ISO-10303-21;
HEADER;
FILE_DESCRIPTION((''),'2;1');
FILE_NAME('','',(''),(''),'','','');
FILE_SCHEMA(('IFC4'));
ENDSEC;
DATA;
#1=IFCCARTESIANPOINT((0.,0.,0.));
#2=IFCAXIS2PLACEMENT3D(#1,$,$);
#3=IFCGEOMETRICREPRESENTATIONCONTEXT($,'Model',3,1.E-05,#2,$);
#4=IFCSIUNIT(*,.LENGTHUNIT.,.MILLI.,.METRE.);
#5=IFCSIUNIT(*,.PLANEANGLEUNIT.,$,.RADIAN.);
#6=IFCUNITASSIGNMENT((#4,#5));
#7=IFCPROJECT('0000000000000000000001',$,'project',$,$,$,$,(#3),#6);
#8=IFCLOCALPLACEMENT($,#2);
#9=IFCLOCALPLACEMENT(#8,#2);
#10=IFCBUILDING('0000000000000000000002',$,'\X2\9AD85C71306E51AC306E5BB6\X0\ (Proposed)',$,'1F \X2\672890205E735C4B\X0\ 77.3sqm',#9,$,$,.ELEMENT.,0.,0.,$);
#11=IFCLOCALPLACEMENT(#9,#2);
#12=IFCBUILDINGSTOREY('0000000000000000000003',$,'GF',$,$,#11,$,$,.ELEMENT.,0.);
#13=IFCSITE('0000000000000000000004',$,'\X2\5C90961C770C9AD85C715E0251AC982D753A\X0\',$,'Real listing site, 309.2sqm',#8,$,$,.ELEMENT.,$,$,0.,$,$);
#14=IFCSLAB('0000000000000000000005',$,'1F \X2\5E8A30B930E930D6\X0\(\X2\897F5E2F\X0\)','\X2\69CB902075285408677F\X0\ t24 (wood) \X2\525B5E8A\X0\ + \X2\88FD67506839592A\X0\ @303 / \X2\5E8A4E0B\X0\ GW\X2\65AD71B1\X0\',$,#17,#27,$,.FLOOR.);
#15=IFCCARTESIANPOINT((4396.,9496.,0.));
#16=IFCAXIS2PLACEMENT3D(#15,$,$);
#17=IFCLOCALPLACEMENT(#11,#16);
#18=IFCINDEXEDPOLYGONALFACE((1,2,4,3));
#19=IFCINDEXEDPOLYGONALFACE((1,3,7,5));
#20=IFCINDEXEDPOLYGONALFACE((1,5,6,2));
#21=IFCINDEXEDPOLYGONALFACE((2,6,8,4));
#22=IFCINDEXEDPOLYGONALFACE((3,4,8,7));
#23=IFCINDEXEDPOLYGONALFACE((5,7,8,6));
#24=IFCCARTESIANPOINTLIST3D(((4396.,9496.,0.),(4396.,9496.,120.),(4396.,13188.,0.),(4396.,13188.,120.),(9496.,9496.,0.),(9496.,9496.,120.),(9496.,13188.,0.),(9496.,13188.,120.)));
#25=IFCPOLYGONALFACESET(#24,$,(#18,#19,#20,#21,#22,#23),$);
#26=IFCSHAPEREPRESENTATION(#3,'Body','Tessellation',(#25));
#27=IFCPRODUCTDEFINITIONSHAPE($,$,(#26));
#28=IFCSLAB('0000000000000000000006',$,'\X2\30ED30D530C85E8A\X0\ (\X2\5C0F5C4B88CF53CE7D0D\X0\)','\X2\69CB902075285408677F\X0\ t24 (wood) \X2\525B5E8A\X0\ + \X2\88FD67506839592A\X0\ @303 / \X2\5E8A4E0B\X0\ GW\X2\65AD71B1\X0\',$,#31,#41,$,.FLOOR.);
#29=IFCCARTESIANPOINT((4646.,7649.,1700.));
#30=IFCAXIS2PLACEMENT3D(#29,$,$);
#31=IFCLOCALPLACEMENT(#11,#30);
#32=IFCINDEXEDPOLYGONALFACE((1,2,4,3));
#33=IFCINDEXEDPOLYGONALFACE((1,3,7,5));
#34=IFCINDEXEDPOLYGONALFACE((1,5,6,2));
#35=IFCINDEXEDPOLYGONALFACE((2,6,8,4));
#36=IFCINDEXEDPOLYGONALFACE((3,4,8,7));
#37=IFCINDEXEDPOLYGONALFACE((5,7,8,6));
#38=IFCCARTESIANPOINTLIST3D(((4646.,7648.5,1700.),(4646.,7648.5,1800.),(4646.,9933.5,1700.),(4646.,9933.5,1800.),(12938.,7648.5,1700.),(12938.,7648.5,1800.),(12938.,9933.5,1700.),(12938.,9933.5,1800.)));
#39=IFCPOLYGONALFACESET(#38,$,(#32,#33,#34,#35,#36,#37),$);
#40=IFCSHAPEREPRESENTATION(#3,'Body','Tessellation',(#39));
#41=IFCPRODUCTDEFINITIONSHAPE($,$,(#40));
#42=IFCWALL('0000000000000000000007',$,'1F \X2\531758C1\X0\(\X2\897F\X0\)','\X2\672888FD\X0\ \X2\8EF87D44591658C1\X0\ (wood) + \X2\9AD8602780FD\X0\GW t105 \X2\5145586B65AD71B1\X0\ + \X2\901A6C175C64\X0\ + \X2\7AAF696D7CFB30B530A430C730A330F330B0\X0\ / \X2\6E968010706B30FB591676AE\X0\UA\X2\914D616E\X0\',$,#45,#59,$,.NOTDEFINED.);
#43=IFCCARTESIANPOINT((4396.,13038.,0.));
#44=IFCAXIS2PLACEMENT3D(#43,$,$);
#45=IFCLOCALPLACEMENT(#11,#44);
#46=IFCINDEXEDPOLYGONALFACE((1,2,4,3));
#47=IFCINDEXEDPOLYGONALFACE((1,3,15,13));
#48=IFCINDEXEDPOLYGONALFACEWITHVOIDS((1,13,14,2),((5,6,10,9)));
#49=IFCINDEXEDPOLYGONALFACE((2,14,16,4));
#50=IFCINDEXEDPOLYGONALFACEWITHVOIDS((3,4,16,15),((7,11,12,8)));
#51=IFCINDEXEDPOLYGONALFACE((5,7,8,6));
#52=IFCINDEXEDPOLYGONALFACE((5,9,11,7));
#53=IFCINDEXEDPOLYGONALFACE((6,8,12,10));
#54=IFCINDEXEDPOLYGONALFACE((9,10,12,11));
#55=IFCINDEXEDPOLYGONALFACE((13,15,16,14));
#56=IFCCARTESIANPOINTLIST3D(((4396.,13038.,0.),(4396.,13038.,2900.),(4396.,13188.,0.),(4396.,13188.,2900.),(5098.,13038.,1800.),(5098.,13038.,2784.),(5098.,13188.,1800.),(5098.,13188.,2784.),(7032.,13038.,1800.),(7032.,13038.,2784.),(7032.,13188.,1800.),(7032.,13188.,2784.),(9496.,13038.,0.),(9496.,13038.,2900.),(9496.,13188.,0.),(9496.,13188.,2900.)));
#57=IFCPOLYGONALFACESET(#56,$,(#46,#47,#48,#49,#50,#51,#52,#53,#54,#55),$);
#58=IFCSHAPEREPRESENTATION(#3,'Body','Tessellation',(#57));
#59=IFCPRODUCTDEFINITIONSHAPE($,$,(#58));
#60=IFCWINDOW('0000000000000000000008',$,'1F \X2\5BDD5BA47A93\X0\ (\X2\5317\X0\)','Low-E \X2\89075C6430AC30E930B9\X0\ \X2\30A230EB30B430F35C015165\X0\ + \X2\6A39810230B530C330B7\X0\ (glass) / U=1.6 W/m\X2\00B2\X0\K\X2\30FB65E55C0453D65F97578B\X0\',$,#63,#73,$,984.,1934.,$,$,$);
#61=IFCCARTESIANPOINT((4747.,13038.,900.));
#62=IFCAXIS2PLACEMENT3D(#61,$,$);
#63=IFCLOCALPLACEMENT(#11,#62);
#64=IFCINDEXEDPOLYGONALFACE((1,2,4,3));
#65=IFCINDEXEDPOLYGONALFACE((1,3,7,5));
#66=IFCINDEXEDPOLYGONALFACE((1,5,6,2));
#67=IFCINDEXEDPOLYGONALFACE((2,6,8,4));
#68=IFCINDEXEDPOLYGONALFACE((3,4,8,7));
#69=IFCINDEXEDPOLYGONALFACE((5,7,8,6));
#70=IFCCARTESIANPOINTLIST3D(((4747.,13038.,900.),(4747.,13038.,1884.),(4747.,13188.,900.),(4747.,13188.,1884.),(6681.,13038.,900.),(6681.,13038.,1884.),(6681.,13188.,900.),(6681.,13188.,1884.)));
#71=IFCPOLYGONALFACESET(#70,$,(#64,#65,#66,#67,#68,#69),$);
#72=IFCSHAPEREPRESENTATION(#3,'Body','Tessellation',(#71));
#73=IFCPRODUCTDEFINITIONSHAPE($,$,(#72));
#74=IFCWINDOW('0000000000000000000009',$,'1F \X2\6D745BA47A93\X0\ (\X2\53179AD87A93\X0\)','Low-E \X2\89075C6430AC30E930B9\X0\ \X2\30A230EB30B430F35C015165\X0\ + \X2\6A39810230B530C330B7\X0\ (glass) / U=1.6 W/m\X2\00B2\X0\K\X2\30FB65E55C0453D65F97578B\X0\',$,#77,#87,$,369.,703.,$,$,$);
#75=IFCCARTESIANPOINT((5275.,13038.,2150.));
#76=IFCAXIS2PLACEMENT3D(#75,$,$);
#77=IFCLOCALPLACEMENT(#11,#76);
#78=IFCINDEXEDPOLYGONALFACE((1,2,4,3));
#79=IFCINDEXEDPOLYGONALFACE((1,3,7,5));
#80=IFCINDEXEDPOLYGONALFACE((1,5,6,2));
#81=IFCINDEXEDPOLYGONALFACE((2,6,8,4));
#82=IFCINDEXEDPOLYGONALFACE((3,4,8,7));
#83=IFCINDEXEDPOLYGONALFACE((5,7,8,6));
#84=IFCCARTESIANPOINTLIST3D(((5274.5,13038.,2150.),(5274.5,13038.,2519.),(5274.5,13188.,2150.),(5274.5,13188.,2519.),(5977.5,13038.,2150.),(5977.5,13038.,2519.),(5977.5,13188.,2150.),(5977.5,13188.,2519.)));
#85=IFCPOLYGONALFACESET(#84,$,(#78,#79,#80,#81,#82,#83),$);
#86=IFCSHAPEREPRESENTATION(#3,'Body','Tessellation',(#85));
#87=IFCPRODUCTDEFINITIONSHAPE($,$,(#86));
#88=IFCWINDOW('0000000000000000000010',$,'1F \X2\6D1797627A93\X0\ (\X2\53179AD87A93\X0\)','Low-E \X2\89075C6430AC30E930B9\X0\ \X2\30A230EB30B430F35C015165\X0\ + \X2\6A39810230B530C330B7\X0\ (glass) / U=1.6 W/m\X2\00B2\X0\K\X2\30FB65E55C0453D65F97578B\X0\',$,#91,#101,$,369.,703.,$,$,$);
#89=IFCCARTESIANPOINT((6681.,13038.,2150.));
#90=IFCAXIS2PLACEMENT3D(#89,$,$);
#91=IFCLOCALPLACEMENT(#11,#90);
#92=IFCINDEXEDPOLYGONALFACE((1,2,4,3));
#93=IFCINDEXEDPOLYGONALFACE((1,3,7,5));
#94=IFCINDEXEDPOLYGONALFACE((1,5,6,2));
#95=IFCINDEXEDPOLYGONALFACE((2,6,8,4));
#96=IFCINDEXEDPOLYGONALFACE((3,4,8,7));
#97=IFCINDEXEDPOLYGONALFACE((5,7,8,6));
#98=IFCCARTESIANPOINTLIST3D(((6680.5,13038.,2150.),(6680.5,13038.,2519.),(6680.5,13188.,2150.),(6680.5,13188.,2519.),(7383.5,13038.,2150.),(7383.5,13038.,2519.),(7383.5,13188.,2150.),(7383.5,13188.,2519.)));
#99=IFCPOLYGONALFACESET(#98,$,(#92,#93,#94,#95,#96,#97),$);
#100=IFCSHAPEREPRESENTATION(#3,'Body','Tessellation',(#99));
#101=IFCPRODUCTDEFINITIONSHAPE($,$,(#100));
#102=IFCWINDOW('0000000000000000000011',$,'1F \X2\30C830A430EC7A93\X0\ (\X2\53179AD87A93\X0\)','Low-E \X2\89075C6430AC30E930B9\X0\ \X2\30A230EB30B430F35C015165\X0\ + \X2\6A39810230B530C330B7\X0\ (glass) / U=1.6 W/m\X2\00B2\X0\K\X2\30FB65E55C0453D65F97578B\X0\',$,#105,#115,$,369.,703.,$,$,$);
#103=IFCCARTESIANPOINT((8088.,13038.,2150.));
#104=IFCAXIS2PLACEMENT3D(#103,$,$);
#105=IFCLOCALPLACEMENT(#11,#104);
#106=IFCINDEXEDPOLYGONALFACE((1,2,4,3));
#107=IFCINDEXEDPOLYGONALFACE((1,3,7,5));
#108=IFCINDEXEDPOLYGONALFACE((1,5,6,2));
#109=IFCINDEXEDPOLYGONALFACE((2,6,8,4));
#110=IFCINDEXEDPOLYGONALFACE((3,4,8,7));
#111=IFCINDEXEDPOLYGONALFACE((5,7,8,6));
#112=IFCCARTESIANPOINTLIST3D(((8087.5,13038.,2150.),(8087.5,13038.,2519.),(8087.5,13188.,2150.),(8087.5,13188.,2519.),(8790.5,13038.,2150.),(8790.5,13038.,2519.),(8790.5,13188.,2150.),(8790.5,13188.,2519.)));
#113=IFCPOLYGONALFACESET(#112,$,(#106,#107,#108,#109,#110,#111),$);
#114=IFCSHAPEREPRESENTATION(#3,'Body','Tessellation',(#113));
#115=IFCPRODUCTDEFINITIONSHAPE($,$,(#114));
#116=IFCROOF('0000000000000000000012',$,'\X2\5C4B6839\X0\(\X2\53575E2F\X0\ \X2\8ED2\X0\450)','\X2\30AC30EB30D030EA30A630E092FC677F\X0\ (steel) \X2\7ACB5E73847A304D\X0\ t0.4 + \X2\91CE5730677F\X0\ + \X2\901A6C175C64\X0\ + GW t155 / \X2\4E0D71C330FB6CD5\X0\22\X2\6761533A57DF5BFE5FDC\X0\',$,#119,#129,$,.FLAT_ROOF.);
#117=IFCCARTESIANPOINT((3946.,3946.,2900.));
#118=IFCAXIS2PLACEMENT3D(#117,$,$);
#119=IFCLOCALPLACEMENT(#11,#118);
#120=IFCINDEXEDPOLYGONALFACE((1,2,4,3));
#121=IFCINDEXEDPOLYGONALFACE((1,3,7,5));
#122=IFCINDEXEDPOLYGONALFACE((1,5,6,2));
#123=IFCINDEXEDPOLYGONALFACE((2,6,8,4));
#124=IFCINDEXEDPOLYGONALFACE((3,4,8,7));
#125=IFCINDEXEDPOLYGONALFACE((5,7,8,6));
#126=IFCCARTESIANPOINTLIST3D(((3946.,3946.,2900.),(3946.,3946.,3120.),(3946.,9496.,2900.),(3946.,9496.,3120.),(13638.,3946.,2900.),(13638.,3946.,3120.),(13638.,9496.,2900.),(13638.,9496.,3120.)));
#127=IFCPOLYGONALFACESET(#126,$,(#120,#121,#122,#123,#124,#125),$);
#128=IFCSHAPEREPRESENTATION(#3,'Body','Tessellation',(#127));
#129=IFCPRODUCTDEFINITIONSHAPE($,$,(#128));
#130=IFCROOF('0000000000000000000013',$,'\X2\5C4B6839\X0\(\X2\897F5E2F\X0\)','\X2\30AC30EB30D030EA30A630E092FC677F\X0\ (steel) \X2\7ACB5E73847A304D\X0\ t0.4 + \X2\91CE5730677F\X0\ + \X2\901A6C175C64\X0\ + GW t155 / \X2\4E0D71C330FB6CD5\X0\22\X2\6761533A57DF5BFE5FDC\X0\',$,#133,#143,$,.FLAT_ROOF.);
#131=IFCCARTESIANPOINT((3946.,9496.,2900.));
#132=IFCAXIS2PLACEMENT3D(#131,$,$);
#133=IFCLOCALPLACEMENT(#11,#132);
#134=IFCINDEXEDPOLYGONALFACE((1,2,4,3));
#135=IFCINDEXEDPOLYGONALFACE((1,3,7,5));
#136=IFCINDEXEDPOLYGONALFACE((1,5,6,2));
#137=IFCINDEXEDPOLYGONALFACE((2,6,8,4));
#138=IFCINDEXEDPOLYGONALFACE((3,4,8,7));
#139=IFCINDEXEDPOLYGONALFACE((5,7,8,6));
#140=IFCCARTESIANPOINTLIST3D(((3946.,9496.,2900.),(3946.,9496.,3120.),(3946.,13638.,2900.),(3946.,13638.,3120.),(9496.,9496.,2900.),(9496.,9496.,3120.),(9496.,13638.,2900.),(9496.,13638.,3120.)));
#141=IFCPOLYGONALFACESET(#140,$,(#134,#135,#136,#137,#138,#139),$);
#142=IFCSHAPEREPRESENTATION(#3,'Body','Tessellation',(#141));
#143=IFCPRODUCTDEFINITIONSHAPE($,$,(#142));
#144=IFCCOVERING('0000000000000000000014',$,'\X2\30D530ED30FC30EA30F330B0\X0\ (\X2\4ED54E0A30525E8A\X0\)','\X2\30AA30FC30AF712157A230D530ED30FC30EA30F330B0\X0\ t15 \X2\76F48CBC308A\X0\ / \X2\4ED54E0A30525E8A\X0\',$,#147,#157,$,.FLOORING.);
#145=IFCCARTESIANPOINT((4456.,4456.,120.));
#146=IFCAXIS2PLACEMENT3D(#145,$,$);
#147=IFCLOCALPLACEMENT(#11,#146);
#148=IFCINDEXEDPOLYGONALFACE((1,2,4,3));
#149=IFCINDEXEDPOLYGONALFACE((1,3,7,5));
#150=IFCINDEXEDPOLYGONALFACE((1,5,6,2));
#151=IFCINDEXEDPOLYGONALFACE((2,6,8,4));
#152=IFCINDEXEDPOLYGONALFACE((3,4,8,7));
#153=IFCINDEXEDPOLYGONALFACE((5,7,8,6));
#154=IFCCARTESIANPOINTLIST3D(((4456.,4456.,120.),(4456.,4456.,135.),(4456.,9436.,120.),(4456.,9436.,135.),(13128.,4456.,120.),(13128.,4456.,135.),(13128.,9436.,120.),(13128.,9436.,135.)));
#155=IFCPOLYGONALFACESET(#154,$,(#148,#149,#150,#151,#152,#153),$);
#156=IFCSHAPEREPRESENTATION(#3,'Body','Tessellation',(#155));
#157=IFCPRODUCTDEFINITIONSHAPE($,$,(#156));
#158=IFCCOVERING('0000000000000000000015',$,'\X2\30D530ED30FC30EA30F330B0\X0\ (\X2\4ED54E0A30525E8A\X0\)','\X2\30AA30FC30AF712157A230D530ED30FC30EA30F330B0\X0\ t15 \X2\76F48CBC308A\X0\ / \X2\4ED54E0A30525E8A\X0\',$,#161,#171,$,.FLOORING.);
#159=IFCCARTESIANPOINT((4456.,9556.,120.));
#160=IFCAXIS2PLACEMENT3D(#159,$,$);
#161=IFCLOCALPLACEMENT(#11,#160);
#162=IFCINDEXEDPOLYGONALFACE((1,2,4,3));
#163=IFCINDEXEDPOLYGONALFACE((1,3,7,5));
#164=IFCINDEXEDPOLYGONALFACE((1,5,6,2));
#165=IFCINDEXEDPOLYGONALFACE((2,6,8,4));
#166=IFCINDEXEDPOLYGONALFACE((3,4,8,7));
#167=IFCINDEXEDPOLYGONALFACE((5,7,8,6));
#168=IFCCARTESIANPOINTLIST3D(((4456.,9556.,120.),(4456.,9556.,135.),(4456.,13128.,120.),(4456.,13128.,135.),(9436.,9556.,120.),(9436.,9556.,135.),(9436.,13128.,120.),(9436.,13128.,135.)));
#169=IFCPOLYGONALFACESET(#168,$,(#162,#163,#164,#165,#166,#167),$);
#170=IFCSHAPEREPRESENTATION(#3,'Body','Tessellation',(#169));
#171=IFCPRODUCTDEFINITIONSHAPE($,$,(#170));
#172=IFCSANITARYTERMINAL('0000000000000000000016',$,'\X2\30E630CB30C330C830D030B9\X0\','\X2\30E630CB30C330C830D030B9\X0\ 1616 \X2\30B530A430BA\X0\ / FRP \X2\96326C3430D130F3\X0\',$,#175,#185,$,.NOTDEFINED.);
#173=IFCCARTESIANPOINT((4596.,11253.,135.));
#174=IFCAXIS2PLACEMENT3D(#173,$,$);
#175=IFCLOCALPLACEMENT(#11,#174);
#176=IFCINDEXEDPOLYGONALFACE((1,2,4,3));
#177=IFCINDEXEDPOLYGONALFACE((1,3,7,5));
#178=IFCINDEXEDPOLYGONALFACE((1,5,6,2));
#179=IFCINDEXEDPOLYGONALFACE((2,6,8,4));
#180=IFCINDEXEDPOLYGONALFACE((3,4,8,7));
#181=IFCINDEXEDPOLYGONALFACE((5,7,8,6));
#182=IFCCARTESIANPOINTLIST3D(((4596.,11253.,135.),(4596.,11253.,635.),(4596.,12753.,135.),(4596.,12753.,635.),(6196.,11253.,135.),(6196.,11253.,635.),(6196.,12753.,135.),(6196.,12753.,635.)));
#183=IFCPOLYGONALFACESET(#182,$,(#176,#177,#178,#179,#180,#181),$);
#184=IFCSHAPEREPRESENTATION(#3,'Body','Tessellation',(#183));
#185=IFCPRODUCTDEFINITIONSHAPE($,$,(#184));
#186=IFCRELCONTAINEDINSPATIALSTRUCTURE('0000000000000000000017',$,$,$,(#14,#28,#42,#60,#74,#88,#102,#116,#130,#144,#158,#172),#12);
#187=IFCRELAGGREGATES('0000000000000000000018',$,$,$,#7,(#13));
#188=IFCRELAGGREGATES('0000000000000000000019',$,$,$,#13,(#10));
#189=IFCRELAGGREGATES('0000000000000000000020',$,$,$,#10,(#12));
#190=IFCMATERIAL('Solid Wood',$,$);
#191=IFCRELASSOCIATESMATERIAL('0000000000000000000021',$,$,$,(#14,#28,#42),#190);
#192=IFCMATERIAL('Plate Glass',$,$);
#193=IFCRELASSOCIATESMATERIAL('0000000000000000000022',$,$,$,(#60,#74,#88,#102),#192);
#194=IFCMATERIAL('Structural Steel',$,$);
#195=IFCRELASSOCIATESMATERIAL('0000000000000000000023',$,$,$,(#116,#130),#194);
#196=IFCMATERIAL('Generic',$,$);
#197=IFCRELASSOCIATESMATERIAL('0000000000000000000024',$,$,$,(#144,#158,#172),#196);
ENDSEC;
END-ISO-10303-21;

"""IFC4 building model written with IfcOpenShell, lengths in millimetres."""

from ifc_helpers import new_model, si_unit, frame, frame_2d, origin, place, context, project, spatial, rectangle, extrude, material, element, fill, save


model = new_model("IFC4")

# Units and contexts
model_context = context("Model", 3, precision=1e-05, world=origin())
ifc_project = project(units=[si_unit("LENGTHUNIT", "METRE", prefix="MILLI"), si_unit("PLANEANGLEUNIT", "RADIAN")], contexts=[model_context])

# Site, building, storey
site_placement = place(None, origin())
site = spatial("IfcSite", under=ifc_project, at=site_placement, Name="岐阜県高山市冬頭町", ObjectType="Real listing site, 309.2sqm", CompositionType="ELEMENT", RefElevation=0.0)
building_placement = place(site_placement, origin())
building = spatial("IfcBuilding", under=site, at=building_placement, Name="高山の冬の家 (Proposed)", ObjectType="1F 木造平屋 77.3sqm", CompositionType="ELEMENT", ElevationOfRefHeight=0.0, ElevationOfTerrain=0.0)
storey_placement = place(building_placement, origin())
storey = spatial("IfcBuildingStorey", under=building, at=storey_placement, Name="GF", CompositionType="ELEMENT", Elevation=0.0)

# Slabs
ifc_material_1 = material(Name="Solid Wood")
slab_1_placement = place(storey_placement, frame((4396.0, 9496.0, 0.0)))
element("IfcSlab", 1, at=slab_1_placement, inside=storey, material=ifc_material_1, Name="1F 床スラブ(西帯)", Description="構造用合板 t24 (wood) 剛床 + 製材根太 @303 / 床下 GW断熱", PredefinedType="FLOOR", context=model_context, shape_type="SweptSolid", body=[
    extrude(rectangle(XDim=5100.0, YDim=3692.0, at=frame_2d((2550.0, 1846.0))), frame((4396.0, 9496.0, 0.0)), (0.0, 0.0, 1.0), 120.0),
])
slab_2_placement = place(storey_placement, frame((4646.0, 7649.0, 1700.0)))
element("IfcSlab", 2, at=slab_2_placement, inside=storey, material=ifc_material_1, Name="ロフト床 (小屋裏収納)", Description="構造用合板 t24 (wood) 剛床 + 製材根太 @303 / 床下 GW断熱", PredefinedType="FLOOR", context=model_context, shape_type="SweptSolid", body=[
    extrude(rectangle(XDim=8292.0, YDim=2285.0, at=frame_2d((4146.0, 1142.0))), frame((4646.0, 7649.0, 1700.0)), (0.0, 0.0, 1.0), 100.0),
])

# Shared definitions
ifc_material_2 = material(Name="Plate Glass")

# Wall, openings, windows
wall_1_placement = place(storey_placement, frame((4396.0, 13038.0, 0.0)))
wall_1 = element("IfcWall", 3, at=wall_1_placement, inside=storey, material=ifc_material_1, Name="1F 北壁(西)", Description="木製 軸組外壁 (wood) + 高性能GW t105 充填断熱 + 通気層 + 窯業系サイディング / 準耐火・外皮UA配慮", PredefinedType="NOTDEFINED", context=model_context, shape_type="SweptSolid", body=[
    extrude(rectangle(XDim=5100.0, YDim=150.0, at=frame_2d((2550.0, 75.0))), frame((4396.0, 13038.0, 0.0)), (0.0, 0.0, 1.0), 2900.0),
])
opening_1_placement = place(storey_placement, frame((4747.0, 13038.0, 900.0)))
opening_1 = element("IfcOpeningElement", 4, at=opening_1_placement, cuts=wall_1, PredefinedType="NOTDEFINED", context=model_context, shape_type="SweptSolid", body=[
    extrude(rectangle(XDim=1934.0, YDim=150.0, at=frame_2d((967.0, 75.0))), frame((4747.0, 13038.0, 900.0)), (0.0, 0.0, 1.0), 984.0),
])
opening_2_placement = place(storey_placement, frame((5275.0, 13038.0, 2150.0)))
opening_2 = element("IfcOpeningElement", 5, at=opening_2_placement, cuts=wall_1, PredefinedType="NOTDEFINED", context=model_context, shape_type="SweptSolid", body=[
    extrude(rectangle(XDim=703.0, YDim=150.0, at=frame_2d((351.0, 75.0))), frame((5275.0, 13038.0, 2150.0)), (0.0, 0.0, 1.0), 369.0),
])
opening_3_placement = place(storey_placement, frame((6681.0, 13038.0, 2150.0)))
opening_3 = element("IfcOpeningElement", 6, at=opening_3_placement, cuts=wall_1, PredefinedType="NOTDEFINED", context=model_context, shape_type="SweptSolid", body=[
    extrude(rectangle(XDim=703.0, YDim=150.0, at=frame_2d((351.0, 75.0))), frame((6681.0, 13038.0, 2150.0)), (0.0, 0.0, 1.0), 369.0),
])
opening_4_placement = place(storey_placement, frame((8088.0, 13038.0, 2150.0)))
opening_4 = element("IfcOpeningElement", 7, at=opening_4_placement, cuts=wall_1, PredefinedType="NOTDEFINED", context=model_context, shape_type="SweptSolid", body=[
    extrude(rectangle(XDim=703.0, YDim=150.0, at=frame_2d((351.0, 75.0))), frame((8088.0, 13038.0, 2150.0)), (0.0, 0.0, 1.0), 369.0),
])
window_1_placement = place(storey_placement, frame((4747.0, 13038.0, 900.0)))
window_1 = element("IfcWindow", 8, at=window_1_placement, inside=storey, material=ifc_material_2, Name="1F 寝室窓 (北)", Description="Low-E 複層ガラス アルゴン封入 + 樹脂サッシ (glass) / U=1.6 W/m²K・日射取得型", OverallHeight=984.0, OverallWidth=1934.0, context=model_context, shape_type="SweptSolid", body=[
    extrude(rectangle(XDim=1934.0, YDim=150.0, at=frame_2d((967.0, 75.0))), frame((4747.0, 13038.0, 900.0)), (0.0, 0.0, 1.0), 984.0),
])
fill(opening_1, window_1)
window_2_placement = place(storey_placement, frame((5275.0, 13038.0, 2150.0)))
window_2 = element("IfcWindow", 9, at=window_2_placement, inside=storey, material=ifc_material_2, Name="1F 浴室窓 (北高窓)", Description="Low-E 複層ガラス アルゴン封入 + 樹脂サッシ (glass) / U=1.6 W/m²K・日射取得型", OverallHeight=369.0, OverallWidth=703.0, context=model_context, shape_type="SweptSolid", body=[
    extrude(rectangle(XDim=703.0, YDim=150.0, at=frame_2d((351.0, 75.0))), frame((5275.0, 13038.0, 2150.0)), (0.0, 0.0, 1.0), 369.0),
])
fill(opening_2, window_2)
window_3_placement = place(storey_placement, frame((6681.0, 13038.0, 2150.0)))
window_3 = element("IfcWindow", 10, at=window_3_placement, inside=storey, material=ifc_material_2, Name="1F 洗面窓 (北高窓)", Description="Low-E 複層ガラス アルゴン封入 + 樹脂サッシ (glass) / U=1.6 W/m²K・日射取得型", OverallHeight=369.0, OverallWidth=703.0, context=model_context, shape_type="SweptSolid", body=[
    extrude(rectangle(XDim=703.0, YDim=150.0, at=frame_2d((351.0, 75.0))), frame((6681.0, 13038.0, 2150.0)), (0.0, 0.0, 1.0), 369.0),
])
fill(opening_3, window_3)
window_4_placement = place(storey_placement, frame((8088.0, 13038.0, 2150.0)))
window_4 = element("IfcWindow", 11, at=window_4_placement, inside=storey, material=ifc_material_2, Name="1F トイレ窓 (北高窓)", Description="Low-E 複層ガラス アルゴン封入 + 樹脂サッシ (glass) / U=1.6 W/m²K・日射取得型", OverallHeight=369.0, OverallWidth=703.0, context=model_context, shape_type="SweptSolid", body=[
    extrude(rectangle(XDim=703.0, YDim=150.0, at=frame_2d((351.0, 75.0))), frame((8088.0, 13038.0, 2150.0)), (0.0, 0.0, 1.0), 369.0),
])
fill(opening_4, window_4)

# Roofs
ifc_material_3 = material(Name="Structural Steel")
roof_1_placement = place(storey_placement, frame((3946.0, 3946.0, 2900.0)))
element("IfcRoof", 12, at=roof_1_placement, inside=storey, material=ifc_material_3, Name="屋根(南帯 軒450)", Description="ガルバリウム鋼板 (steel) 立平葺き t0.4 + 野地板 + 通気層 + GW t155 / 不燃・法22条区域対応", PredefinedType="FLAT_ROOF", context=model_context, shape_type="SweptSolid", body=[
    extrude(rectangle(XDim=9692.0, YDim=5550.0, at=frame_2d((4846.0, 2775.0))), frame((3946.0, 3946.0, 2900.0)), (0.0, 0.0, 1.0), 220.0),
])
roof_2_placement = place(storey_placement, frame((3946.0, 9496.0, 2900.0)))
element("IfcRoof", 13, at=roof_2_placement, inside=storey, material=ifc_material_3, Name="屋根(西帯)", Description="ガルバリウム鋼板 (steel) 立平葺き t0.4 + 野地板 + 通気層 + GW t155 / 不燃・法22条区域対応", PredefinedType="FLAT_ROOF", context=model_context, shape_type="SweptSolid", body=[
    extrude(rectangle(XDim=5550.0, YDim=4142.0, at=frame_2d((2775.0, 2071.0))), frame((3946.0, 9496.0, 2900.0)), (0.0, 0.0, 1.0), 220.0),
])

# Coverings
ifc_material_4 = material(Name="Generic")
covering_1_placement = place(storey_placement, frame((4456.0, 4456.0, 120.0)))
element("IfcCovering", 14, at=covering_1_placement, inside=storey, material=ifc_material_4, Name="フローリング (仕上げ床)", Description="オーク無垢フローリング t15 直貼り / 仕上げ床", PredefinedType="FLOORING", context=model_context, shape_type="SweptSolid", body=[
    extrude(rectangle(XDim=8672.0, YDim=4980.0, at=frame_2d((4336.0, 2490.0))), frame((4456.0, 4456.0, 120.0)), (0.0, 0.0, 1.0), 15.0),
])
covering_2_placement = place(storey_placement, frame((4456.0, 9556.0, 120.0)))
element("IfcCovering", 15, at=covering_2_placement, inside=storey, material=ifc_material_4, Name="フローリング (仕上げ床)", Description="オーク無垢フローリング t15 直貼り / 仕上げ床", PredefinedType="FLOORING", context=model_context, shape_type="SweptSolid", body=[
    extrude(rectangle(XDim=4980.0, YDim=3572.0, at=frame_2d((2490.0, 1786.0))), frame((4456.0, 9556.0, 120.0)), (0.0, 0.0, 1.0), 15.0),
])

# Sanitary terminal
sanitary_terminal_placement = place(storey_placement, frame((4596.0, 11253.0, 135.0)))
element("IfcSanitaryTerminal", 16, at=sanitary_terminal_placement, inside=storey, material=ifc_material_4, Name="ユニットバス", Description="ユニットバス 1616 サイズ / FRP 防水パン", PredefinedType="NOTDEFINED", context=model_context, shape_type="SweptSolid", body=[
    extrude(rectangle(XDim=1600.0, YDim=1500.0, at=frame_2d((800.0, 750.0))), frame((4596.0, 11253.0, 135.0)), (0.0, 0.0, 1.0), 500.0),
])

save(model, "model.ifc")
